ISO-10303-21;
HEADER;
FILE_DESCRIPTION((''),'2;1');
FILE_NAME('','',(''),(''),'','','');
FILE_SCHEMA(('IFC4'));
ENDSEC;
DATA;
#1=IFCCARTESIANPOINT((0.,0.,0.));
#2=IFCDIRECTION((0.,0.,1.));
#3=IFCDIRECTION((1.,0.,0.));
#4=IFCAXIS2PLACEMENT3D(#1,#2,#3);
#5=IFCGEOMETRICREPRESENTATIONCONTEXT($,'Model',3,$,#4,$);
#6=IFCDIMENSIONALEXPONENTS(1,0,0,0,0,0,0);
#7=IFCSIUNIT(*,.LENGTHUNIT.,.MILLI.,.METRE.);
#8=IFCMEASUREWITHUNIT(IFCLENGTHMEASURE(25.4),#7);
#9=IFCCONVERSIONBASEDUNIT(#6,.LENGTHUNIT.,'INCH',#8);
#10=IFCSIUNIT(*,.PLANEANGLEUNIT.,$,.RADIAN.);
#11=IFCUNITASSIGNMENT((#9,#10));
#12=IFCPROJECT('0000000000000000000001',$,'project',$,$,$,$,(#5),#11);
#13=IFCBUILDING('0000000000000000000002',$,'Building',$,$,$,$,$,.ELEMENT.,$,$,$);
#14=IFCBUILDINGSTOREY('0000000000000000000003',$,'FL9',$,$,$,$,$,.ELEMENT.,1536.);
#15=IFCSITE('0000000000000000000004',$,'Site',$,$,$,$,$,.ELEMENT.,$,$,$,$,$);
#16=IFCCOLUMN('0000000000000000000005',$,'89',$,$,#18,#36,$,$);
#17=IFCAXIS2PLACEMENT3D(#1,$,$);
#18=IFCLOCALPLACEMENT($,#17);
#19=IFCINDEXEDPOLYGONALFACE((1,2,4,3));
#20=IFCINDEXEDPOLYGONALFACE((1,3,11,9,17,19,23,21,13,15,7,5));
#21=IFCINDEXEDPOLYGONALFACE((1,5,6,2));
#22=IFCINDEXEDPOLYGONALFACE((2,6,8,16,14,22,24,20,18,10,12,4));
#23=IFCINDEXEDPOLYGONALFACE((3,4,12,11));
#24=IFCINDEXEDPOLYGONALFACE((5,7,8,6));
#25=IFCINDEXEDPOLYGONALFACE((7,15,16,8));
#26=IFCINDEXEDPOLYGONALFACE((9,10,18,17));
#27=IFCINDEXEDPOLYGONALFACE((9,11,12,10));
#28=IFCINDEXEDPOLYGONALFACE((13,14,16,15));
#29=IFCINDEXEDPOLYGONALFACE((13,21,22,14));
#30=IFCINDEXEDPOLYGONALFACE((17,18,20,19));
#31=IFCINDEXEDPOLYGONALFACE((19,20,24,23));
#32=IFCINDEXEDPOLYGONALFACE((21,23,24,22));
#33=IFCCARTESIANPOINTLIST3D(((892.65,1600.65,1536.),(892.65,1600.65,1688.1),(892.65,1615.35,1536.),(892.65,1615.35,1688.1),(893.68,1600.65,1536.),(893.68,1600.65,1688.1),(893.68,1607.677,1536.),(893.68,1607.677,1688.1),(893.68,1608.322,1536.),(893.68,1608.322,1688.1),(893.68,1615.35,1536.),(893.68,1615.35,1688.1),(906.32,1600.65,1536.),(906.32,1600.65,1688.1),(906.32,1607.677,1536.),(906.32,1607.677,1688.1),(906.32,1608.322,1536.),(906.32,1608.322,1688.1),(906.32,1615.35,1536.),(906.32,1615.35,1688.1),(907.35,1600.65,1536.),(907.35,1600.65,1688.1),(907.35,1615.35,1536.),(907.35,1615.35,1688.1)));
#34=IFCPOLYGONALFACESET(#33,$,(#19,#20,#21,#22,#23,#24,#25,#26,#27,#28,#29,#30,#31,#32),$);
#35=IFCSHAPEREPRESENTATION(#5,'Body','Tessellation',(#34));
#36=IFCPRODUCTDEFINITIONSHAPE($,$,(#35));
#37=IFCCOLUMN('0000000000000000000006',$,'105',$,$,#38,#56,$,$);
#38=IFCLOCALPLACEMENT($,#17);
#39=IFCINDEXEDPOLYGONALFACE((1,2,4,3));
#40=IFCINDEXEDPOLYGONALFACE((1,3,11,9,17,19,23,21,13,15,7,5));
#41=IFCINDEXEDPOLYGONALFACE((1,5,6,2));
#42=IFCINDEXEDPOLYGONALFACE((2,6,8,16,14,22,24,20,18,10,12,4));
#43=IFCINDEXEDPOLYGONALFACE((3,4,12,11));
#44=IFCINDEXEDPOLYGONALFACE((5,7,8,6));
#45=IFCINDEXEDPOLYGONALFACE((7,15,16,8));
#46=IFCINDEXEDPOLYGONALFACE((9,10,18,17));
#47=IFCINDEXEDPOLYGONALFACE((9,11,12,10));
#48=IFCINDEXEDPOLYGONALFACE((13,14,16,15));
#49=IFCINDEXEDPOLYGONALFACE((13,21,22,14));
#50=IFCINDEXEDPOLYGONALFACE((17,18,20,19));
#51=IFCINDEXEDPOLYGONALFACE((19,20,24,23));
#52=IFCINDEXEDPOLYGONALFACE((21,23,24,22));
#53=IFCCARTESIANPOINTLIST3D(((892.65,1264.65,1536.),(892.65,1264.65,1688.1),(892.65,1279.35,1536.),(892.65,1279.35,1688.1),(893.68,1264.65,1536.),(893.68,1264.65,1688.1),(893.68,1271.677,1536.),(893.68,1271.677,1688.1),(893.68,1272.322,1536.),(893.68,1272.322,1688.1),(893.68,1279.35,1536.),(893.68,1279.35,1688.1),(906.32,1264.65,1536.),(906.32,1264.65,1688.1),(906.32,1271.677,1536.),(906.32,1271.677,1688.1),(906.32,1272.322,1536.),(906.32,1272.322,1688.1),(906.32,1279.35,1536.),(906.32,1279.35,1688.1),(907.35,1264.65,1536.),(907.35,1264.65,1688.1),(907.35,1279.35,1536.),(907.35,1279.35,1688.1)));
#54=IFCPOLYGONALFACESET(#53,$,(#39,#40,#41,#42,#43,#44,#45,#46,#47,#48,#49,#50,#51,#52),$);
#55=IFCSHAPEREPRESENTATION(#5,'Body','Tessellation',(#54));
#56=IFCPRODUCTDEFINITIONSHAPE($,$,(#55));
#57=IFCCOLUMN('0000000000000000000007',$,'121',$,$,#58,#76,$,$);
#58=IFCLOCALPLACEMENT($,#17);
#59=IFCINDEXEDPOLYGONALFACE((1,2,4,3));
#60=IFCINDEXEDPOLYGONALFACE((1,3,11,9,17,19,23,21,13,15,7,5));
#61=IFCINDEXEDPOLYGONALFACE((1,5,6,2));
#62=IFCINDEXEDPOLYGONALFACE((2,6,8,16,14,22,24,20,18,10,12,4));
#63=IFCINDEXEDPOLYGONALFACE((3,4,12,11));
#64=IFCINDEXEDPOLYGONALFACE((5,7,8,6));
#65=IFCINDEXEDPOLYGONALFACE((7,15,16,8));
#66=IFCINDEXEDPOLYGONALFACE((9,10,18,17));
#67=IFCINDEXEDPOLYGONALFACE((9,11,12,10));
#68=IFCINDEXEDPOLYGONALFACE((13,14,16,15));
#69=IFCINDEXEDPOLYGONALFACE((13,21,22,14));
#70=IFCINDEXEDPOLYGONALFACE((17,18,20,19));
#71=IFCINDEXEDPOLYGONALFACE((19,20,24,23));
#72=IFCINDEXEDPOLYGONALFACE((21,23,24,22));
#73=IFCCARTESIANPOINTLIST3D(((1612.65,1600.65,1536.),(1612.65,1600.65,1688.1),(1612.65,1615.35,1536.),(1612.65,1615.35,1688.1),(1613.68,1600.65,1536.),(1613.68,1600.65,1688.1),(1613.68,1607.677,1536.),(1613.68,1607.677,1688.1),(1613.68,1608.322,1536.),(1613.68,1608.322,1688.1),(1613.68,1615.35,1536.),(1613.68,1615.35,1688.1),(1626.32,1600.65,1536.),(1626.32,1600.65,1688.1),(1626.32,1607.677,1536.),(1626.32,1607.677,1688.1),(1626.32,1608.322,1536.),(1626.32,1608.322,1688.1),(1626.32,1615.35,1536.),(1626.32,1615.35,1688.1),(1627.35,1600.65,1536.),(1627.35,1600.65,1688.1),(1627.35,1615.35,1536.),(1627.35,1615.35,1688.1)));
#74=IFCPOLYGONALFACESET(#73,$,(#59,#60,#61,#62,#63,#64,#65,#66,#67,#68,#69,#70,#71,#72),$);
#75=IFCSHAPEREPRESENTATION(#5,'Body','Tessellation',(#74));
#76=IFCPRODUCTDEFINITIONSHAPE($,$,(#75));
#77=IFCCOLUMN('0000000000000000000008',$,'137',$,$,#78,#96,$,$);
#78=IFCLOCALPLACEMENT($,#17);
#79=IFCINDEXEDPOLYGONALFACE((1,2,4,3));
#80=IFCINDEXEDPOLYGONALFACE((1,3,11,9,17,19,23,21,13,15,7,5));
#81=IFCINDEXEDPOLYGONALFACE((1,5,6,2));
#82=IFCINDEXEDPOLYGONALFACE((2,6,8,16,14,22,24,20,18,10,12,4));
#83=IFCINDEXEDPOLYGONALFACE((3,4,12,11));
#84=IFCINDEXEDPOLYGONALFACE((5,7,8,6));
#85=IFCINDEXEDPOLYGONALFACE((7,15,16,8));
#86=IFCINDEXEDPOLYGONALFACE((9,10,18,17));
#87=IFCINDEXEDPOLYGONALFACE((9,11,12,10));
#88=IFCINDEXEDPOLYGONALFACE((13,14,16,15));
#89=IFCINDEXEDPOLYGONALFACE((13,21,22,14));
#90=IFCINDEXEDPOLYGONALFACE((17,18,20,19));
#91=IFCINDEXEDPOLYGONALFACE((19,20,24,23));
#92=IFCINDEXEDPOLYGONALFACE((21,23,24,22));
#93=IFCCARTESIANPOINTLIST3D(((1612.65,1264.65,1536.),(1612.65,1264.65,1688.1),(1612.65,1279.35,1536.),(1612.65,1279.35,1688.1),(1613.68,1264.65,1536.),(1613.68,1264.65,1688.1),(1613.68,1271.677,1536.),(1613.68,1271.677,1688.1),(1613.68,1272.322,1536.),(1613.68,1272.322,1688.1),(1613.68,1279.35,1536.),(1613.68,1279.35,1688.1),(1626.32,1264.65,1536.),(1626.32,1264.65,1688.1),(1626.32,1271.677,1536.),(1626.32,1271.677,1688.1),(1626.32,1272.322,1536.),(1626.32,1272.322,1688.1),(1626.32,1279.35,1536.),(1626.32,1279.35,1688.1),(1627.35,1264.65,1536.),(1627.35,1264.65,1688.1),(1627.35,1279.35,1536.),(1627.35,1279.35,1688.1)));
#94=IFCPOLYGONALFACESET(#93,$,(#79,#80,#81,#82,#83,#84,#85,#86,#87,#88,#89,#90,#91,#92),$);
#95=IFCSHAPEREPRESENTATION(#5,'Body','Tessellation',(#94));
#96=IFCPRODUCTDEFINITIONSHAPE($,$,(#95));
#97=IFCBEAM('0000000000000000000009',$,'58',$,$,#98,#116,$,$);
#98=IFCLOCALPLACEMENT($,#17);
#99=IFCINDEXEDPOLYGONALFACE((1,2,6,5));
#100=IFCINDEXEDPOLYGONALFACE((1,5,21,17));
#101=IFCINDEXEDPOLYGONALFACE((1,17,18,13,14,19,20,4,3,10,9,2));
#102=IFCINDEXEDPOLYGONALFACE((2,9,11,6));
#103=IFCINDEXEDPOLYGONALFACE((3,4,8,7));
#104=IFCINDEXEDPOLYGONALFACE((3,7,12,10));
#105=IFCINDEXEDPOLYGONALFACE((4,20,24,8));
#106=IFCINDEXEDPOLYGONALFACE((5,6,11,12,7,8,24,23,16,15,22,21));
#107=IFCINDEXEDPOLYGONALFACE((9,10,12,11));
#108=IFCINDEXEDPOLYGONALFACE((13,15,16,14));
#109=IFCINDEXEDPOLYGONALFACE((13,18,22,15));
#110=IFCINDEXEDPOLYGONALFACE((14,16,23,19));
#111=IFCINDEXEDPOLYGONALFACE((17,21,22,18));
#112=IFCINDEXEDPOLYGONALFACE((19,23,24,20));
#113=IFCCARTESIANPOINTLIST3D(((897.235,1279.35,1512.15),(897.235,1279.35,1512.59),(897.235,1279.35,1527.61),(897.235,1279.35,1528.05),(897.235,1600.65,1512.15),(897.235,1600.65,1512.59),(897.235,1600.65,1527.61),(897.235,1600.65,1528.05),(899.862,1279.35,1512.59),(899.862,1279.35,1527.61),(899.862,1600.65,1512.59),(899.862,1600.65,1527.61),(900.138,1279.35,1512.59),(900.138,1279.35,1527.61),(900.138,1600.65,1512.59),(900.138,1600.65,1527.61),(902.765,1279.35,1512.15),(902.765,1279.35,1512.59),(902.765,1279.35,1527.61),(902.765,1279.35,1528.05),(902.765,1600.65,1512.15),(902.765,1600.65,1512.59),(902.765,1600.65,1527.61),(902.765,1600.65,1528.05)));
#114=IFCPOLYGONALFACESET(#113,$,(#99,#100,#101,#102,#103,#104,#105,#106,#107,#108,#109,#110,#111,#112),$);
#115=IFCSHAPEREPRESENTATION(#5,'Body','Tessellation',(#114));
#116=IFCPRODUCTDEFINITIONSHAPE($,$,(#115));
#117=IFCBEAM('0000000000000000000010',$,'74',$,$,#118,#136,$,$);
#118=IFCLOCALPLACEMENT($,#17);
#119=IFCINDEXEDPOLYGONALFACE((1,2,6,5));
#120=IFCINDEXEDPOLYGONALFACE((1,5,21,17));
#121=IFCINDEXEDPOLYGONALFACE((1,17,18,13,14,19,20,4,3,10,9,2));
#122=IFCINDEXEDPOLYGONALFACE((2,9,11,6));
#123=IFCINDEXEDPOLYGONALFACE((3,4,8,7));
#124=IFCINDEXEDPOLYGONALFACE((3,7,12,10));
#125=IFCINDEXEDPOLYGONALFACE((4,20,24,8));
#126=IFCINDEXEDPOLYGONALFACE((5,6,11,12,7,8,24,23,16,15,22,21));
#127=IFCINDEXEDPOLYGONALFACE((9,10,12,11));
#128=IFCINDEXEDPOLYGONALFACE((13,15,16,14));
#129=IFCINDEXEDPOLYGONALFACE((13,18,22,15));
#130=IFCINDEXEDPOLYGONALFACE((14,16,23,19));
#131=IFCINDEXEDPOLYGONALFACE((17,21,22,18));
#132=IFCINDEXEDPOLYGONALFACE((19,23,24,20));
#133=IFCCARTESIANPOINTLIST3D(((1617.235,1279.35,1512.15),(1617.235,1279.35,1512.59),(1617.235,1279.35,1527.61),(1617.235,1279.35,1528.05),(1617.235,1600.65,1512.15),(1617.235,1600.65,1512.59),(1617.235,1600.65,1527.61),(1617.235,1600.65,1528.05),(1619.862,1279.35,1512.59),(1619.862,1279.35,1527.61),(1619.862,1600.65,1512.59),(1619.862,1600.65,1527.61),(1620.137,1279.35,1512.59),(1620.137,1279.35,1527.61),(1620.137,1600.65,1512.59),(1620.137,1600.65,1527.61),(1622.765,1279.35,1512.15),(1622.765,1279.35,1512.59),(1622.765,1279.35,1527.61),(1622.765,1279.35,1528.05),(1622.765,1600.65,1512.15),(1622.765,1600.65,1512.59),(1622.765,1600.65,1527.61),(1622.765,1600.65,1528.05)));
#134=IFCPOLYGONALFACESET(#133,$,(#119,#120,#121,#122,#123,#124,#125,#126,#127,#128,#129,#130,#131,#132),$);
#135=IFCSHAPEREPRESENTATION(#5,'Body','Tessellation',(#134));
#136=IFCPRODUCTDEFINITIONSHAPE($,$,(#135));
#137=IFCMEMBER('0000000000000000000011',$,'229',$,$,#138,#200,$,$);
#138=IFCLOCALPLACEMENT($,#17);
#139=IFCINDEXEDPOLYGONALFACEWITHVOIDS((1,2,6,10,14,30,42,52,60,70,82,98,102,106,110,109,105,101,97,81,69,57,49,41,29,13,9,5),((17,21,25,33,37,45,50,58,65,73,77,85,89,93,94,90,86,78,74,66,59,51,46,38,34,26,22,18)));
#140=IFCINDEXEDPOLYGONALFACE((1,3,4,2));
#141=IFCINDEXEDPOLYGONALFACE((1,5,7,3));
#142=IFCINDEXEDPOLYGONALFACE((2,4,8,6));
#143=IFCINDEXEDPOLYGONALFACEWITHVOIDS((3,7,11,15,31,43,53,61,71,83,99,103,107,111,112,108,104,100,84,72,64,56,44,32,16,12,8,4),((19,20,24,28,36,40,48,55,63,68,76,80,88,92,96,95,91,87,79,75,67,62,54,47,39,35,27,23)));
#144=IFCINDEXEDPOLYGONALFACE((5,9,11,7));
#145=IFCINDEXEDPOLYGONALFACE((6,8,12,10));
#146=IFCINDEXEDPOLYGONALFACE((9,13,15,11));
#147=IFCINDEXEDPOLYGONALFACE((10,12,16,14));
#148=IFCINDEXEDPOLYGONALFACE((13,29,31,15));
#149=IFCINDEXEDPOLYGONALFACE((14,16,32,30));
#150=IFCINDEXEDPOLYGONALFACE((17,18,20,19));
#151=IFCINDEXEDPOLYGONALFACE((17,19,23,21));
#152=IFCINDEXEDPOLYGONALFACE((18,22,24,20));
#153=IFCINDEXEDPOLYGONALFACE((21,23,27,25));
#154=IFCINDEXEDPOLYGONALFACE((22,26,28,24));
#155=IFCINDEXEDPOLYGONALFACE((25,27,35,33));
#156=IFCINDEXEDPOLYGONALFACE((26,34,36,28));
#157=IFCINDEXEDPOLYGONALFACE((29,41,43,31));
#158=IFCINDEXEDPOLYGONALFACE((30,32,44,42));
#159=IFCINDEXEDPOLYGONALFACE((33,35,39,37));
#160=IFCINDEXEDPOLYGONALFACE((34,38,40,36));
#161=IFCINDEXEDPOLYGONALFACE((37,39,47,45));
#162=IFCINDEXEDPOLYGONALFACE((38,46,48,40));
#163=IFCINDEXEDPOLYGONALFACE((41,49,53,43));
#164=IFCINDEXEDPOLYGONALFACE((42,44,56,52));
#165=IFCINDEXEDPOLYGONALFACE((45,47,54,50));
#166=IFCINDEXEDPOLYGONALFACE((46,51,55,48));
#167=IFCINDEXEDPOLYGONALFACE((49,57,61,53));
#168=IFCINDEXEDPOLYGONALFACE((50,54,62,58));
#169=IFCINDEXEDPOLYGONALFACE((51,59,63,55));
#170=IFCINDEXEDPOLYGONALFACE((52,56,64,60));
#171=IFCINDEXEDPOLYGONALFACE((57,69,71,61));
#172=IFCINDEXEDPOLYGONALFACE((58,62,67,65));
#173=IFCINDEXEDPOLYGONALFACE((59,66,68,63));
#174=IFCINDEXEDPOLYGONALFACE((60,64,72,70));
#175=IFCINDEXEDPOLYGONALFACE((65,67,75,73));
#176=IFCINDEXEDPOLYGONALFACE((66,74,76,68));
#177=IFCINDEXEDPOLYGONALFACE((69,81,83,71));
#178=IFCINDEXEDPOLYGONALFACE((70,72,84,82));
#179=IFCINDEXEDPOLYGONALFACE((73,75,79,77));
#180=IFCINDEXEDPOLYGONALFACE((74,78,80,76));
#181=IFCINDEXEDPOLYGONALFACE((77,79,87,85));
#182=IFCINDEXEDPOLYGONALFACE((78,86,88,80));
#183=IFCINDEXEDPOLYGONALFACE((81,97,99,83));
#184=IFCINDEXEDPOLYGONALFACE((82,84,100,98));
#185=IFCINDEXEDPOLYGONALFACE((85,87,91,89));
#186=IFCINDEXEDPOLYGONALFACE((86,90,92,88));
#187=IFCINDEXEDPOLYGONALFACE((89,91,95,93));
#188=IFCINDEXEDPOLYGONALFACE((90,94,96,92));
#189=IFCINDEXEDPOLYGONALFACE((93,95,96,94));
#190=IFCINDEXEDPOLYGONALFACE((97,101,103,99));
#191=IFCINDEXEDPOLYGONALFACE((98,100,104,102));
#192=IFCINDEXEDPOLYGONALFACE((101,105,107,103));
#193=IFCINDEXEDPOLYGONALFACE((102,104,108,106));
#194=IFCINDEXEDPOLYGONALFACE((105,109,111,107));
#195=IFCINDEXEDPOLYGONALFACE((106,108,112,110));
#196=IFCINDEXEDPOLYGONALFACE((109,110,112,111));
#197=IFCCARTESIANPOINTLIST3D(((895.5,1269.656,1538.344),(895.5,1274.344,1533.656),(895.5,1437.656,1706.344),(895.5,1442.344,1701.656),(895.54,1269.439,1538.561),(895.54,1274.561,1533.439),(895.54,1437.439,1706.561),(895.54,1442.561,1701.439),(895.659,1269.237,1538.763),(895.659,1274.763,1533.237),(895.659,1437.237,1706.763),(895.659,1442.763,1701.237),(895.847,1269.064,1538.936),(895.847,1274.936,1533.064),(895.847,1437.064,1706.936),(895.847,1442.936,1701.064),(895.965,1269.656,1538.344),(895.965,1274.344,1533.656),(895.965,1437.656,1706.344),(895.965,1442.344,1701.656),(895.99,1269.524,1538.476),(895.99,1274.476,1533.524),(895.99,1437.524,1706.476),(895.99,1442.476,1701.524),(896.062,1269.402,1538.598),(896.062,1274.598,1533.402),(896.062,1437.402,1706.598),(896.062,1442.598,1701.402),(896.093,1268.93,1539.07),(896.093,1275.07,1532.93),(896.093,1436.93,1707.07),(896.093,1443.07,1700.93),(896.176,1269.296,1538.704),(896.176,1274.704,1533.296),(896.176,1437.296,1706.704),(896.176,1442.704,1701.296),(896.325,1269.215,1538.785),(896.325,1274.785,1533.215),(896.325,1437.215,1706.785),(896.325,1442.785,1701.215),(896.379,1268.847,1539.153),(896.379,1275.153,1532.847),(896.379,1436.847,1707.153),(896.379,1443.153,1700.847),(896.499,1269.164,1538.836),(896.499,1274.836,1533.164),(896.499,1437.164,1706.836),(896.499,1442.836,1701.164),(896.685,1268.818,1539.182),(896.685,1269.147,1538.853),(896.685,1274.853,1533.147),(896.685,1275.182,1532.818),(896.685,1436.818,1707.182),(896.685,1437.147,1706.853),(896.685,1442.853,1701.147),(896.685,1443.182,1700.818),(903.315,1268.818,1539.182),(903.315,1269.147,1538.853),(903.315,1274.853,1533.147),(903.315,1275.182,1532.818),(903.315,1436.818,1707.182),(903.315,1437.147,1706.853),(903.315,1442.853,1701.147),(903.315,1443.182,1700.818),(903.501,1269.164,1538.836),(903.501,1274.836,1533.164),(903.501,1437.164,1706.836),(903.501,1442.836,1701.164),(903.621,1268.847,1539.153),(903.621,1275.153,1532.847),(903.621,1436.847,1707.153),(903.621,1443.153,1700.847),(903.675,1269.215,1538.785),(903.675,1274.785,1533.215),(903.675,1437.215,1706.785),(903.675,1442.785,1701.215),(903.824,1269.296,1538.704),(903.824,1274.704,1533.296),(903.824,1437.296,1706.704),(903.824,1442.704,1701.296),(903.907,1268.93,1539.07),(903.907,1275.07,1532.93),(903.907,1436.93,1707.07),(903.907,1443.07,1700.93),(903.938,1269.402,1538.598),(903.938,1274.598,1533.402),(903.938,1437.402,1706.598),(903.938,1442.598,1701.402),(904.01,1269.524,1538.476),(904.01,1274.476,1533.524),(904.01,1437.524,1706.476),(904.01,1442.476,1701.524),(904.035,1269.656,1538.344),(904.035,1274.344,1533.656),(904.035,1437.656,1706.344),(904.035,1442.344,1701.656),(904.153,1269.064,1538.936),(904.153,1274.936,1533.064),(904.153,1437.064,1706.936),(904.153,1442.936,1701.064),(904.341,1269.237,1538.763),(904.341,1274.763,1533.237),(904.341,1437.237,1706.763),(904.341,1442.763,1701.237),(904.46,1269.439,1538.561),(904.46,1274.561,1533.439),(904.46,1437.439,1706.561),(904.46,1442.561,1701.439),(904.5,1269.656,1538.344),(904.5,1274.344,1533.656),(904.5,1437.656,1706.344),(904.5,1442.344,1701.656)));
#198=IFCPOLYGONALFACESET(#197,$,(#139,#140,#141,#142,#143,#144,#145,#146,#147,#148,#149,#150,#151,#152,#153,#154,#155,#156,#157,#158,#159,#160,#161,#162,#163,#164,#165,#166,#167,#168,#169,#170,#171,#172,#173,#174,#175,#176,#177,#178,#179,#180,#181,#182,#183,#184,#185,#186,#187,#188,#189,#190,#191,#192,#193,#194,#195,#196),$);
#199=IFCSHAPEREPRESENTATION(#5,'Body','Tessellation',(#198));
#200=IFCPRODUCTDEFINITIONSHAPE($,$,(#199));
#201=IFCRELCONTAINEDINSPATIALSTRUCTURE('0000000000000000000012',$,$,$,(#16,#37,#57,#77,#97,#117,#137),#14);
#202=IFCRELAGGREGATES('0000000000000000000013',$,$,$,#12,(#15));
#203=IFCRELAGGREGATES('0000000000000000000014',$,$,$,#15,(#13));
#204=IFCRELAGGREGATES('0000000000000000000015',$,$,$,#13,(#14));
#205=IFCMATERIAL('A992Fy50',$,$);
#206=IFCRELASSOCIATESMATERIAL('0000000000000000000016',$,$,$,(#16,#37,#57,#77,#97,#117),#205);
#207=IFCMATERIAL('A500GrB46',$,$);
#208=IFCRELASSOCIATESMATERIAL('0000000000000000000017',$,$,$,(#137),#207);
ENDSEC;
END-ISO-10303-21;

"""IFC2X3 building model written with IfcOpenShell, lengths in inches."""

from ifc_helpers import new_model, entity, si_unit, converted_unit, frame, origin_with_axes, origin_2d_with_axis, place, context, project, spatial, hollow_rectangle, i_section, transform_2d, derived_profile, extrude, material, element, save


model = new_model("IFC2X3")

# Units and contexts
model_context = context("Model", 3, world=origin_with_axes())
ifc_project = project(units=[converted_unit("LENGTHUNIT", "INCH", entity("IfcLengthMeasure", 25.4), si_unit("LENGTHUNIT", "METRE", prefix="MILLI"), dimensions=[1, 0, 0, 0, 0, 0, 0]), si_unit("PLANEANGLEUNIT", "RADIAN")], contexts=[model_context])

# Site, building, storey
site = spatial("IfcSite", under=ifc_project, Name="Site", CompositionType="ELEMENT")
building = spatial("IfcBuilding", under=site, Name="Building", CompositionType="ELEMENT")
storey = spatial("IfcBuildingStorey", under=building, Name="FL9", CompositionType="ELEMENT", Elevation=1536.0)

# Columns
ifc_material_1 = material(Name="A992Fy50")
for number, where, z_axis, x_axis, name in (
    (1, (900.0, 1608.0, 1536.0), (0.0, 0.0, 1.0), (0.0, -1.0, 0.0), "89"),
    (2, (900.0, 1272.0, 1536.0), (0.0, 0.0, 1.0), (0.0, -1.0, 0.0), "105"),
    (3, (1620.0, 1608.0, 1536.0), (0.0, 0.0, 1.0), (0.0, -1.0, 0.0), "121"),
    (4, (1620.0, 1272.0, 1536.0), (0.0, 0.0, 1.0), (0.0, -1.0, 0.0), "137"),
):
    element("IfcColumn", number, at=place(None, frame(where, z_axis=z_axis, x_axis=x_axis)), inside=storey, material=ifc_material_1, Name=name, context=model_context, shape_type="SweptSolid", body=[
        extrude(i_section(OverallWidth=14.7, OverallDepth=14.7, WebThickness=0.645, FlangeThickness=1.03, at=origin_2d_with_axis()), origin_with_axes(), (0.0, 0.0, 1.0), 152.1),
    ])

# Beams
for number, where, z_axis, x_axis, name in (
    (5, (900.0, 1279.35, 1536.0), (0.0, 1.0, 0.0), (-1.0, 0.0, 0.0), "58"),
    (6, (1620.0, 1279.35, 1536.0), (0.0, 1.0, 0.0), (-1.0, 0.0, 0.0), "74"),
):
    element("IfcBeam", number, at=place(None, frame(where, z_axis=z_axis, x_axis=x_axis)), inside=storey, material=ifc_material_1, Name=name, context=model_context, shape_type="SweptSolid", body=[
        extrude(derived_profile(i_section(OverallWidth=5.53, OverallDepth=15.9, WebThickness=0.275, FlangeThickness=0.44, at=origin_2d_with_axis()), transform_2d((0.0, -7.95))), origin_with_axes(), (0.0, 0.0, 1.0), 321.3),
    ])

# Member
ifc_material_2 = material(Name="A500GrB46")
for number, where, z_axis, x_axis, name in (
    (7, (900.0, 1272.0, 1536.0), (0.0, 0.707107, 0.707107), (-1.0, 0.0, 0.0), "229"),
):
    element("IfcMember", number, at=place(None, frame(where, z_axis=z_axis, x_axis=x_axis)), inside=storey, material=ifc_material_2, Name=name, context=model_context, shape_type="SweptSolid", body=[
        extrude(hollow_rectangle(XDim=9.0, YDim=9.0, WallThickness=0.465, InnerFilletRadius=0.72, OuterFilletRadius=1.185, at=origin_2d_with_axis()), origin_with_axes(), (0.0, 0.0, 1.0), 237.588),
    ])

save(model, "model.ifc")
